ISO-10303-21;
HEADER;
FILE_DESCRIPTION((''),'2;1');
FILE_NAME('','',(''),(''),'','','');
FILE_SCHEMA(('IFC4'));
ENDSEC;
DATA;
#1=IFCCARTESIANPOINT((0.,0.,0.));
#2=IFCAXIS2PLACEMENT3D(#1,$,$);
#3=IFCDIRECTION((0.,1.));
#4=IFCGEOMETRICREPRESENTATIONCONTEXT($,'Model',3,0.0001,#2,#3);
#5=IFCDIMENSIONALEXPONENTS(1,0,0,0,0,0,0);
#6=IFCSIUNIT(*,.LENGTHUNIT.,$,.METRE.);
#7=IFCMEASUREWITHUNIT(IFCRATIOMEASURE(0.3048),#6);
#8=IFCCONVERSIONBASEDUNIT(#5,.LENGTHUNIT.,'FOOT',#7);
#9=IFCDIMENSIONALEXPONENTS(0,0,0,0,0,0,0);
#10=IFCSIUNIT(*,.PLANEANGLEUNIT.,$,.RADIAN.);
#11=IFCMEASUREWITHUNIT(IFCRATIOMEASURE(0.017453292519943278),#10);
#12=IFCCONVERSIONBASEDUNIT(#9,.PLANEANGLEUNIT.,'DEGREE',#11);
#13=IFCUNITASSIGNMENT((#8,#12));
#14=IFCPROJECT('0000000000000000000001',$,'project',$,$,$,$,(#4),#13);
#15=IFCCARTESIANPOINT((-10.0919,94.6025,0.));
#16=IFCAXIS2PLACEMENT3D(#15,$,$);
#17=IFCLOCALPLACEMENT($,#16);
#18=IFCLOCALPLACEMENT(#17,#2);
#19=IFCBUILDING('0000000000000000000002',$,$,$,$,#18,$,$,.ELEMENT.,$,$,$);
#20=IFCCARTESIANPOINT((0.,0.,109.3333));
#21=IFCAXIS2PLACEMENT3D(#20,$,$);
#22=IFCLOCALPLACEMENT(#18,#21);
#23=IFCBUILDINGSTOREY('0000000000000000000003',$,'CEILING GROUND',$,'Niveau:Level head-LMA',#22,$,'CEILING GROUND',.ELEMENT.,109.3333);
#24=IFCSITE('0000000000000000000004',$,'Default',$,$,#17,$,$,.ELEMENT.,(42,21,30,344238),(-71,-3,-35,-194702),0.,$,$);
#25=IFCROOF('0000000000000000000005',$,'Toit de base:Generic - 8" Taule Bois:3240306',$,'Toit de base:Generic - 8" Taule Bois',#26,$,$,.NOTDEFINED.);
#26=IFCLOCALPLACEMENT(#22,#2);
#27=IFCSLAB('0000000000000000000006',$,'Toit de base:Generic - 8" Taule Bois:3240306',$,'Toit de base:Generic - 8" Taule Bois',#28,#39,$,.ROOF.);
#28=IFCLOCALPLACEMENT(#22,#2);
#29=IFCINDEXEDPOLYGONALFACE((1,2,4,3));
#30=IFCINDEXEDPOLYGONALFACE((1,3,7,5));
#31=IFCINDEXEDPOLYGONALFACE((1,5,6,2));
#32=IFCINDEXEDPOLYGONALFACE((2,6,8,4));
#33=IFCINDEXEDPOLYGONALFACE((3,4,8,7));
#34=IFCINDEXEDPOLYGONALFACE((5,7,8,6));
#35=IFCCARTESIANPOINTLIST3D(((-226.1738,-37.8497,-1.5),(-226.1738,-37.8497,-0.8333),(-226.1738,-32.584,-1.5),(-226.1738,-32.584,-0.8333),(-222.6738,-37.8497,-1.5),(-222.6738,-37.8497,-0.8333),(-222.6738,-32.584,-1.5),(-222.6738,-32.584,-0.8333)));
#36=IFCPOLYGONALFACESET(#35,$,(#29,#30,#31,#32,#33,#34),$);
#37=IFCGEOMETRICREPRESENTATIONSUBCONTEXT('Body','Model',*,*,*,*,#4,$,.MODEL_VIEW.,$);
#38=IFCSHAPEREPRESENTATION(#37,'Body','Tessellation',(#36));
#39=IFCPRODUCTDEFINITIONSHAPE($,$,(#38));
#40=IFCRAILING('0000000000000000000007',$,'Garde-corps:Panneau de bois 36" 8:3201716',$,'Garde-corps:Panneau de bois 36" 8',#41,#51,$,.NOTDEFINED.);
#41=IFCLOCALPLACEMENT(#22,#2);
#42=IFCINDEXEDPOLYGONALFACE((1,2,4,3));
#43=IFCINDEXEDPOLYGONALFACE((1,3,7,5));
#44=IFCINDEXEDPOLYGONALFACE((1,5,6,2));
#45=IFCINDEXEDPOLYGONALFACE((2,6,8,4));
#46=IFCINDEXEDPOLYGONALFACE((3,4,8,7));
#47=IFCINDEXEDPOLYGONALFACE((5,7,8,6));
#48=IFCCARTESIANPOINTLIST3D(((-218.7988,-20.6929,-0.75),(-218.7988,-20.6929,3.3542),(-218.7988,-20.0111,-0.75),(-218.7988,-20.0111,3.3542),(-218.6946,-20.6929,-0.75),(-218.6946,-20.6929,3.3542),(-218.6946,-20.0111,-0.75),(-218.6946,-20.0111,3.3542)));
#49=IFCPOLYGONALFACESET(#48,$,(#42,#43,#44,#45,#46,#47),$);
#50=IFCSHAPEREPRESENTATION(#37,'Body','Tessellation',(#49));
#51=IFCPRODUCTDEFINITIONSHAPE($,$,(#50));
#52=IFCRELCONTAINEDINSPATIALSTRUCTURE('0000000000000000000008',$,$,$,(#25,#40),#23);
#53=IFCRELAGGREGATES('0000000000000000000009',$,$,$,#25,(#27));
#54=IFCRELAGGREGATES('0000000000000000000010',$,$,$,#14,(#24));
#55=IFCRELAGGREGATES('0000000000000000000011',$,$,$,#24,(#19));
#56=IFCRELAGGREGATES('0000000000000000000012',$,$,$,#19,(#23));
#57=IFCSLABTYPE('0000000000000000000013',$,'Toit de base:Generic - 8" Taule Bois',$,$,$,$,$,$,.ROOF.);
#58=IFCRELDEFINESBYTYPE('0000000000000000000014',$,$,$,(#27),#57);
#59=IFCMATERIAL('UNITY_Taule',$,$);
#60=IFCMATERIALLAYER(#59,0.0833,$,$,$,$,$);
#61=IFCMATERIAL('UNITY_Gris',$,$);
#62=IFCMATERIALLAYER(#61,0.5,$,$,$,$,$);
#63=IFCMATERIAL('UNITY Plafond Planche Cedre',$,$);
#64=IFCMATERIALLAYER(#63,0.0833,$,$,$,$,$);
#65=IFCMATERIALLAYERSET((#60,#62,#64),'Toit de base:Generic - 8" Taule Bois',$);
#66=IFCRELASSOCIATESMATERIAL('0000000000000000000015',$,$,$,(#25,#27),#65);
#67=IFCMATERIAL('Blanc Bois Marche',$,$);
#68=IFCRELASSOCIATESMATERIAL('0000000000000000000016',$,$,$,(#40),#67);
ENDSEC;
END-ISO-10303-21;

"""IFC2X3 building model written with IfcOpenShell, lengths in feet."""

from ifc_helpers import new_model, entity, si_unit, converted_unit, direction, frame, frame_2d, origin, place, context, subcontext, project, spatial, rectangle, extrude, material, layer, layer_set, type_object, element, aggregate, save


model = new_model("IFC2X3")

# Units and contexts
model_context = context("Model", 3, precision=0.0001, world=origin(), true_north=direction((0.0, 1.0)))
body_context = subcontext(model_context, "Body", "Model", "MODEL_VIEW")
ifc_project = project(units=[converted_unit("LENGTHUNIT", "FOOT", entity("IfcRatioMeasure", 0.3048), si_unit("LENGTHUNIT", "METRE"), dimensions=[1, 0, 0, 0, 0, 0, 0]), converted_unit("PLANEANGLEUNIT", "DEGREE", entity("IfcRatioMeasure", 0.017453292519943278), si_unit("PLANEANGLEUNIT", "RADIAN"), dimensions=[0, 0, 0, 0, 0, 0, 0])], contexts=[model_context])

# Site, building, storey
site_placement = place(None, frame((-10.0919, 94.6025, 0.0)))
site = spatial("IfcSite", under=ifc_project, at=site_placement, Name="Default", CompositionType="ELEMENT", RefLatitude=(42, 21, 30, 344238), RefLongitude=(-71, -3, -35, -194702), RefElevation=0.0)
building_placement = place(site_placement, origin())
building = spatial("IfcBuilding", under=site, at=building_placement, CompositionType="ELEMENT")
storey_placement = place(building_placement, frame((0.0, 0.0, 109.3333)))
storey = spatial("IfcBuildingStorey", under=building, at=storey_placement, Name="CEILING GROUND", ObjectType="Niveau:Level head-LMA", LongName="CEILING GROUND", CompositionType="ELEMENT", Elevation=109.3333)

# Roof, slab
ifc_material_1 = material(Name="UNITY_Taule")
ifc_layer_1 = layer(ifc_material_1, 0.0833)
ifc_material_2 = material(Name="UNITY_Gris")
ifc_layer_2 = layer(ifc_material_2, 0.5)
ifc_material_3 = material(Name="UNITY Plafond Planche Cedre")
ifc_layer_3 = layer(ifc_material_3, 0.0833)
ifc_layer_set = layer_set([ifc_layer_1, ifc_layer_2, ifc_layer_3], Name="Toit de base:Generic - 8\" Taule Bois")
roof_placement = place(storey_placement, frame((-226.1738, -37.8497, -1.5)))
roof = element("IfcRoof", 1, at=roof_placement, inside=storey, material=ifc_layer_set, Name="Toit de base:Generic - 8\" Taule Bois:3240306", ObjectType="Toit de base:Generic - 8\" Taule Bois", ShapeType="NOTDEFINED")
slab_type = type_object("IfcSlabType", Name="Toit de base:Generic - 8\" Taule Bois", PredefinedType="ROOF")
slab_placement = place(roof_placement, origin())
slab = element("IfcSlab", 2, at=slab_placement, type_object=slab_type, material=ifc_layer_set, Name="Toit de base:Generic - 8\" Taule Bois:3240306", ObjectType="Toit de base:Generic - 8\" Taule Bois", PredefinedType="ROOF", context=body_context, shape_type="SweptSolid", body=[
    extrude(rectangle(XDim=3.5, YDim=5.2657, at=frame_2d((0.0, 0.0), x_axis=(-1.0, 0.0))), frame((1.75, 2.6329, 0.0)), (0.0, 0.0, 1.0), 0.6667),
])
aggregate(roof, [slab])

# Railing
ifc_material_4 = material(Name="Blanc Bois Marche")
railing_1_placement = place(storey_placement, origin())
element("IfcRailing", 3, at=railing_1_placement, inside=storey, material=ifc_material_4, Name="Garde-corps:Panneau de bois 36\" 8:3201716", ObjectType="Garde-corps:Panneau de bois 36\" 8", PredefinedType="NOTDEFINED", context=body_context, shape_type="SweptSolid", body=[
    extrude(rectangle(XDim=0.6818, YDim=0.1042, at=frame_2d((0.0, 0.0), x_axis=(1.0, 0.0))), frame((-218.7467, -20.352, -0.75), z_axis=(0.0, 0.0, 1.0), x_axis=(0.0, 1.0, 0.0)), (0.0, 0.0, 1.0), 4.1042),
])

save(model, "model.ifc")
